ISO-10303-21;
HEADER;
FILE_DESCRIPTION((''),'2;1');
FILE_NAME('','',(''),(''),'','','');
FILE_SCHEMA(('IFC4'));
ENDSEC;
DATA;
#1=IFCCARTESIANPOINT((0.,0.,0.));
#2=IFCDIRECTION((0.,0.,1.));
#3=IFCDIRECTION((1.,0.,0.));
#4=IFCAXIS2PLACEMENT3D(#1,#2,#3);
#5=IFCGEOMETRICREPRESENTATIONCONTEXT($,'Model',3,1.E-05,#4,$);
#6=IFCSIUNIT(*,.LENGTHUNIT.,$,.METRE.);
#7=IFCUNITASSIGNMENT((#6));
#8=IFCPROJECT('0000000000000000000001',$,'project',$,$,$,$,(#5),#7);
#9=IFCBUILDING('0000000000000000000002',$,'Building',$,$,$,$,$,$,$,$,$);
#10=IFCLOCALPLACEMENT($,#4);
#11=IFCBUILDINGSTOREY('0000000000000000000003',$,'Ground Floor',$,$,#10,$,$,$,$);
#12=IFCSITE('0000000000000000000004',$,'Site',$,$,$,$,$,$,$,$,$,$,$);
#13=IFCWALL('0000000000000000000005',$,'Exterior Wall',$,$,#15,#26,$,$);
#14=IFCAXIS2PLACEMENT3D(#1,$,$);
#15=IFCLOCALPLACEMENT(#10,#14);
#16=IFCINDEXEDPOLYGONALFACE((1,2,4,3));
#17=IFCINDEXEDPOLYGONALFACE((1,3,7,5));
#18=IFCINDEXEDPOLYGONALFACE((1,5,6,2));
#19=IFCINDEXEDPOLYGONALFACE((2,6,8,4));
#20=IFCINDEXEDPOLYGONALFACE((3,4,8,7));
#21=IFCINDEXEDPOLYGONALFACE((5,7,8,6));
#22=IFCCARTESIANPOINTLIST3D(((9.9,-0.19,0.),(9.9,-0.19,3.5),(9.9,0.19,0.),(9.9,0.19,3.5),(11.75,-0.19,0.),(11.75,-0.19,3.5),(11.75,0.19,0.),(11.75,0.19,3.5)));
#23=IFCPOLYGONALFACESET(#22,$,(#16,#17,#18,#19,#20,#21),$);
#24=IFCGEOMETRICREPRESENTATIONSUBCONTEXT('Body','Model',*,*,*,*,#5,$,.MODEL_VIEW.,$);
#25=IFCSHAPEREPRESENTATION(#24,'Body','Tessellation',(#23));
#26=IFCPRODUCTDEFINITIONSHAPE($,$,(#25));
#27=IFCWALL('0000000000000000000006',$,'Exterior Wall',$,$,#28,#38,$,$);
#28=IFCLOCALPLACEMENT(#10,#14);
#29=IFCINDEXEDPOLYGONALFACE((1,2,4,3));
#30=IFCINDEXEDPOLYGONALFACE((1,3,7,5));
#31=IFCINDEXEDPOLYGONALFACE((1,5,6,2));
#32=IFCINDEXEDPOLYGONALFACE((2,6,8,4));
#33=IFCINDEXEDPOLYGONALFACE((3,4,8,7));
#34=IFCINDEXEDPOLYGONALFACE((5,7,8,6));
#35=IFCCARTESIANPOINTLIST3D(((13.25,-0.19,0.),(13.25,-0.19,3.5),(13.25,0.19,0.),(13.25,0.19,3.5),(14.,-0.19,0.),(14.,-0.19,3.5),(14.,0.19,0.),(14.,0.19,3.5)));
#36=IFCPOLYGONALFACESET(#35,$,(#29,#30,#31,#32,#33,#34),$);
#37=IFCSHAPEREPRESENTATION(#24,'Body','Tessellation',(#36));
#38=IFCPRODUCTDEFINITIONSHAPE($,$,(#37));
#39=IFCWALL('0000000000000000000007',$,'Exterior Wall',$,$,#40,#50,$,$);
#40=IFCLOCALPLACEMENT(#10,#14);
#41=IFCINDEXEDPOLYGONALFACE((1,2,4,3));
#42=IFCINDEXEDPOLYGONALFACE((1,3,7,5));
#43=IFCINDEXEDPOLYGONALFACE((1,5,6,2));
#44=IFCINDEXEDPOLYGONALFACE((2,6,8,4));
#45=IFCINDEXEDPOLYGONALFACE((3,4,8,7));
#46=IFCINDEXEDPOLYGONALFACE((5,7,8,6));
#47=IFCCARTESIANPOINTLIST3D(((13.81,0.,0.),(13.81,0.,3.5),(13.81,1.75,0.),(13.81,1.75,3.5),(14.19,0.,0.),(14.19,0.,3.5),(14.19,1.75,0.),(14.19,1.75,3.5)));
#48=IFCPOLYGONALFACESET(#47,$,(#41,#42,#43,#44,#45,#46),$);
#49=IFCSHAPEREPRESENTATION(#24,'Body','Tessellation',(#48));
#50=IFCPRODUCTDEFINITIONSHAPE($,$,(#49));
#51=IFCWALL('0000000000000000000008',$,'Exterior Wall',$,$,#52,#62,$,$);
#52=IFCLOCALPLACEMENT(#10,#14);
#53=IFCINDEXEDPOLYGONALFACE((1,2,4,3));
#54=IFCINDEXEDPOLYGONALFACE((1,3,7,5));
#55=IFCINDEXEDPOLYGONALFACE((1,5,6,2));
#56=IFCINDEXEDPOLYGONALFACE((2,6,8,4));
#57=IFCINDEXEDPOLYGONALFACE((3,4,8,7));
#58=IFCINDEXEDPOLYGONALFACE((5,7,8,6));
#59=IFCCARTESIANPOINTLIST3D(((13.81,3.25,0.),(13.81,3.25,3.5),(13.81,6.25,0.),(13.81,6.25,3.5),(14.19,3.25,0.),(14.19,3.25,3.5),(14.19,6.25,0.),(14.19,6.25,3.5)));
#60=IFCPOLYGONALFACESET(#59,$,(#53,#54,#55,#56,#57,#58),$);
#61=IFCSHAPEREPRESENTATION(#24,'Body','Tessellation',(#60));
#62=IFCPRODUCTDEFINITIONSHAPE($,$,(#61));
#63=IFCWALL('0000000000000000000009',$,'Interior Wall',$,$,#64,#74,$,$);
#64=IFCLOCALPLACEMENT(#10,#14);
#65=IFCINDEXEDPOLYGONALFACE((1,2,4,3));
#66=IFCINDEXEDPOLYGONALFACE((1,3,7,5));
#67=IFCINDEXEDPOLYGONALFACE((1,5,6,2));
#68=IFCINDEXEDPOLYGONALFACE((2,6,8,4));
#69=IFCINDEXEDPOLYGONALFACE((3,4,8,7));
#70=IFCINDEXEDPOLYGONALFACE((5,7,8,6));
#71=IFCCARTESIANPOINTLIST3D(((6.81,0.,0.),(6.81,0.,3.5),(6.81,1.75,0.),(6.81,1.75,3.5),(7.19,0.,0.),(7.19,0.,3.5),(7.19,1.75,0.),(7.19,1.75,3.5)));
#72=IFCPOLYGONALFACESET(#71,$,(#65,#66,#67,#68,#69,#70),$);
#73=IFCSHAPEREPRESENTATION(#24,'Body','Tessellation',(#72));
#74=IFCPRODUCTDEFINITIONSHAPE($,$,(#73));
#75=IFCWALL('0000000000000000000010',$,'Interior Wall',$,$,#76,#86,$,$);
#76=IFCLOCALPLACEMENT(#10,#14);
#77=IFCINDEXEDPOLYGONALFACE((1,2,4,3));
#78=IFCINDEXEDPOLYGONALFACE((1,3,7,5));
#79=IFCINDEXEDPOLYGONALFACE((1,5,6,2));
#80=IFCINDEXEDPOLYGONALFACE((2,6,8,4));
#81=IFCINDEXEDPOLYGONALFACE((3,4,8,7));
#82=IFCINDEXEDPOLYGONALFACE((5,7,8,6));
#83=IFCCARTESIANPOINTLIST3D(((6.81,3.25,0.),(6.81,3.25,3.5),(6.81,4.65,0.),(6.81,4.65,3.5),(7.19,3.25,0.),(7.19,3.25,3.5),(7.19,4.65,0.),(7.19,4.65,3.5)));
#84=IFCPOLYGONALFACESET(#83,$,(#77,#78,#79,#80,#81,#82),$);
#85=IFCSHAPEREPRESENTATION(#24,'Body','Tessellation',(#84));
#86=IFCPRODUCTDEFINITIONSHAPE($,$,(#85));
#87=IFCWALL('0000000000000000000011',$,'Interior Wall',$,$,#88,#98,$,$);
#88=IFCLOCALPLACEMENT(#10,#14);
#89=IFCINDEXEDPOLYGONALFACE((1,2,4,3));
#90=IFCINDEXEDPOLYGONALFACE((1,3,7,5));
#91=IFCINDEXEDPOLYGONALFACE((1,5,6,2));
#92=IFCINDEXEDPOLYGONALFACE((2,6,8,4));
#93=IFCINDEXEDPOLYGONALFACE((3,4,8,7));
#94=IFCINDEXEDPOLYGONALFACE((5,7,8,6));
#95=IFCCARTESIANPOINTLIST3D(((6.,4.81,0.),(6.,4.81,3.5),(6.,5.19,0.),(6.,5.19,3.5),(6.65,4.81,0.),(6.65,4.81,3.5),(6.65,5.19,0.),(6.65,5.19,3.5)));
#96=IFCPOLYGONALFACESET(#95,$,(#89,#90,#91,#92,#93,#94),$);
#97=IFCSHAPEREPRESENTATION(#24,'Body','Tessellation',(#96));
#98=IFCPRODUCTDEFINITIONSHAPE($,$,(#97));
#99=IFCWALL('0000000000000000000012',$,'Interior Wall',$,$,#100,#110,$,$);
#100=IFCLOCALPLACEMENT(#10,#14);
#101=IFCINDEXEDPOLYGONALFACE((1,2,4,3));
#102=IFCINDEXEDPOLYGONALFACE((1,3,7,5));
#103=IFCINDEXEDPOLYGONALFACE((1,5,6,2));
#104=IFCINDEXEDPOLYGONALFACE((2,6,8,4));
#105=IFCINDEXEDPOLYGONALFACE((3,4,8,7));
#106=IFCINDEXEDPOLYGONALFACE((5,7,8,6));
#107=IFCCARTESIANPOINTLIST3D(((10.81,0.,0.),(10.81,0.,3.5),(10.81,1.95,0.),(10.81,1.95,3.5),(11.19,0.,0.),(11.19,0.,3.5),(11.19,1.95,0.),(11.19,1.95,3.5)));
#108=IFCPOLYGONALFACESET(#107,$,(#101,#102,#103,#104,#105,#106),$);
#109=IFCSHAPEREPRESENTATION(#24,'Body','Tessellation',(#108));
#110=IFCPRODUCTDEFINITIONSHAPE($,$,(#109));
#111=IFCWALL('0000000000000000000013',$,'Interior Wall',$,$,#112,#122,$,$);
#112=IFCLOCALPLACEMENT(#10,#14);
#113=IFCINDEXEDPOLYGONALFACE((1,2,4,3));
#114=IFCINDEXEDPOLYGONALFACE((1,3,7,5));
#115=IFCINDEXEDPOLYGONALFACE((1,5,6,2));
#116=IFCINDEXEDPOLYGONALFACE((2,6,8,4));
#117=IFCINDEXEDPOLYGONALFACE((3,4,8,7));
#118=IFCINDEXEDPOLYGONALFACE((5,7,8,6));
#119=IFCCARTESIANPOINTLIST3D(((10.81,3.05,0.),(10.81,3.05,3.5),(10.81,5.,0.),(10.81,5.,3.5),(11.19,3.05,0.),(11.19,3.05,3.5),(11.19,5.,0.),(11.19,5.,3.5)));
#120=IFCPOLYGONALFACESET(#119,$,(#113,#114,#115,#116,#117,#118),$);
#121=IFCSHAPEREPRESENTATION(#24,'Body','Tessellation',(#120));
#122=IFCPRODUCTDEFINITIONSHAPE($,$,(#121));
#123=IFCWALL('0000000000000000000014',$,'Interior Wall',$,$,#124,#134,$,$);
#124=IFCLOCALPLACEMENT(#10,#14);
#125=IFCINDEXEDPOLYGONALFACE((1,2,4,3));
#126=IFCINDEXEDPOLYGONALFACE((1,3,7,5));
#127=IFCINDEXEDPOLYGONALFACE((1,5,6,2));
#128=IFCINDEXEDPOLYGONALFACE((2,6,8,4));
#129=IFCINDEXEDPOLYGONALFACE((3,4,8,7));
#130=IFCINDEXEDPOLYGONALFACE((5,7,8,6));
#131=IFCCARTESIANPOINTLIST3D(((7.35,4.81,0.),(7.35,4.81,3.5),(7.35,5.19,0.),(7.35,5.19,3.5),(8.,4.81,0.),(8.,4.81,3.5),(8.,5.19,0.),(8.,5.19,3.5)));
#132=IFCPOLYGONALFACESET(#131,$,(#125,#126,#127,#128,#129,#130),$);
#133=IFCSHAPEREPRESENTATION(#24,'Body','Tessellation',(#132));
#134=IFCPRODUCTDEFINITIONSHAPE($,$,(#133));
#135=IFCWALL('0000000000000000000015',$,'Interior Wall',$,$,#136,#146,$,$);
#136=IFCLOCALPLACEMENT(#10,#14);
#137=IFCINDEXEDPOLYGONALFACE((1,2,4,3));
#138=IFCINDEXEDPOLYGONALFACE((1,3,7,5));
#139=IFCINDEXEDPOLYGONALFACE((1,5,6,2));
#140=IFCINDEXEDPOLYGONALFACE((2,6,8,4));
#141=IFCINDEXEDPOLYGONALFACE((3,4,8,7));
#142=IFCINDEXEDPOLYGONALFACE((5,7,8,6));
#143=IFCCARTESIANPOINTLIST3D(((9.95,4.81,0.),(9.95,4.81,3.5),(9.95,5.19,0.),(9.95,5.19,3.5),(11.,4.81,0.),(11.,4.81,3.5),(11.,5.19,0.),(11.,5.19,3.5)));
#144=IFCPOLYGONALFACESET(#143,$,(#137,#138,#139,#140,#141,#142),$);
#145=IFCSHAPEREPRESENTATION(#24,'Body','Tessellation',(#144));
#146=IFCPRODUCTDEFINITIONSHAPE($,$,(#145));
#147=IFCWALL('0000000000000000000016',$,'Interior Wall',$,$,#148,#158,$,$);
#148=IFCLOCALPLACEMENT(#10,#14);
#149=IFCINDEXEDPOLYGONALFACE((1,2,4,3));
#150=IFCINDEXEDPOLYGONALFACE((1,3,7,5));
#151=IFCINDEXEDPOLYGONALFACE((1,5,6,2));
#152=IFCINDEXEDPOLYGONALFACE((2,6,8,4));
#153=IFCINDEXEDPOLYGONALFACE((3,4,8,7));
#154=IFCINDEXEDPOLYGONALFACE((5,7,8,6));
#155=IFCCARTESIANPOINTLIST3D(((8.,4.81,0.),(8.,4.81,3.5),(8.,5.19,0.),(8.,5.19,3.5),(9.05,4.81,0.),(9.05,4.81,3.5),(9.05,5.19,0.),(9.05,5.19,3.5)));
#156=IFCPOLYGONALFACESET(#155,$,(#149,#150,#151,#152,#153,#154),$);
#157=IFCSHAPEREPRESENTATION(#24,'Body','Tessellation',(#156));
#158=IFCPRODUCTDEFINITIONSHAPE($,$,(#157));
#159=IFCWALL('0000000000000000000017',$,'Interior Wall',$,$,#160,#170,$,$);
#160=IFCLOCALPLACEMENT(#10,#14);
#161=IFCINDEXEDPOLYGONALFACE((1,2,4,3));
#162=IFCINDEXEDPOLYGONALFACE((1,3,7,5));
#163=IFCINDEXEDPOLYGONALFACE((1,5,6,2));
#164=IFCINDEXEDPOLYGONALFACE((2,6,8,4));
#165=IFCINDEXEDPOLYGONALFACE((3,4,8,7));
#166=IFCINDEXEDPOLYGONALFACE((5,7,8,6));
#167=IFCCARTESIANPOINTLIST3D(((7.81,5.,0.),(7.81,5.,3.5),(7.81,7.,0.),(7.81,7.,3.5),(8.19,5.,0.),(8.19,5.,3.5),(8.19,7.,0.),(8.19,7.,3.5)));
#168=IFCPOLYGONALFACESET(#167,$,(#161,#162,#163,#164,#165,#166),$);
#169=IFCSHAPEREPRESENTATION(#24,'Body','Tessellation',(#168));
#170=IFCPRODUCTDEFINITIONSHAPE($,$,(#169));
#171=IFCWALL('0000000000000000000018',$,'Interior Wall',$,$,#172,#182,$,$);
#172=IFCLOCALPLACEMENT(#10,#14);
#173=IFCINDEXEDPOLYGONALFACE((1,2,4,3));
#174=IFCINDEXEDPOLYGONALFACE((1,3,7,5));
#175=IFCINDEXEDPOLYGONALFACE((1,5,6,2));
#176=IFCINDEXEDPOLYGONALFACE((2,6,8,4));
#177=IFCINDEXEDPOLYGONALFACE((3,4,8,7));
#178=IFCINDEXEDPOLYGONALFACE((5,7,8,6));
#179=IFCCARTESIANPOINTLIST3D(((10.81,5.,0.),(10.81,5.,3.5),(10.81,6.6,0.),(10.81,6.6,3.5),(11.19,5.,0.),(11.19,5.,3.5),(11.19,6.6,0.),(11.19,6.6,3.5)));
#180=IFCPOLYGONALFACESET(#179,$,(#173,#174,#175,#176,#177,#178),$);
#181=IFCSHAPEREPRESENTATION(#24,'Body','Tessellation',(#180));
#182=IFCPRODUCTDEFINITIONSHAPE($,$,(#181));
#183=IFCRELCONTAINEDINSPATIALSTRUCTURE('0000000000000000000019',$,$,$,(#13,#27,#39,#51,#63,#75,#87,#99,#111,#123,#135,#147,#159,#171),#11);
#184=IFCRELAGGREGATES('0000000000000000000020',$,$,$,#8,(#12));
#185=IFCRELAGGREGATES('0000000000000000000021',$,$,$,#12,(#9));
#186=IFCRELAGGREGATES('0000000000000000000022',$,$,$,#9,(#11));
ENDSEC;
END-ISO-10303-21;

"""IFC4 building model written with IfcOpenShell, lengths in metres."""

from ifc_helpers import new_model, si_unit, frame, origin_with_axes, place, context, subcontext, project, spatial, indexed_curve, outline, extrude, element, save


model = new_model("IFC4")

# Units and contexts
model_context = context("Model", 3, precision=1e-05, world=origin_with_axes())
body_context = subcontext(model_context, "Body", "Model", "MODEL_VIEW")
ifc_project = project(units=[si_unit("LENGTHUNIT", "METRE")], contexts=[model_context])

# Site, building, storey
site = spatial("IfcSite", under=ifc_project, Name="Site")
building = spatial("IfcBuilding", under=site, Name="Building")
storey_placement = place(None, origin_with_axes())
storey = spatial("IfcBuildingStorey", under=building, at=storey_placement, Name="Ground Floor")

# Walls
wall_1_placement = place(storey_placement, frame((9.9, 0.0, 0.0), z_axis=(0.0, 0.0, 1.0), x_axis=(1.0, 0.0, 0.0)))
element("IfcWall", 1, at=wall_1_placement, inside=storey, Name="Exterior Wall", context=body_context, shape_type="SweptSolid", body=[
    extrude(outline(indexed_curve([(0.0, 0.0), (0.0, 0.38), (1.85, 0.38), (1.85, 0.0), (0.0, 0.0)], self_intersect=False)), frame((0.0, -0.19, 0.0), z_axis=(0.0, 0.0, 1.0), x_axis=(1.0, 0.0, 0.0)), (0.0, 0.0, 1.0), 3.5),
])
wall_2_placement = place(storey_placement, frame((13.25, 0.0, 0.0), z_axis=(0.0, 0.0, 1.0), x_axis=(1.0, 0.0, 0.0)))
element("IfcWall", 2, at=wall_2_placement, inside=storey, Name="Exterior Wall", context=body_context, shape_type="SweptSolid", body=[
    extrude(outline(indexed_curve([(0.0, 0.0), (0.0, 0.38), (0.75, 0.38), (0.75, 0.0), (0.0, 0.0)], self_intersect=False)), frame((0.0, -0.19, 0.0), z_axis=(0.0, 0.0, 1.0), x_axis=(1.0, 0.0, 0.0)), (0.0, 0.0, 1.0), 3.5),
])
wall_3_placement = place(storey_placement, frame((14.0, 0.0, 0.0), z_axis=(0.0, 0.0, 1.0), x_axis=(0.0, 1.0, 0.0)))
element("IfcWall", 3, at=wall_3_placement, inside=storey, Name="Exterior Wall", context=body_context, shape_type="SweptSolid", body=[
    extrude(outline(indexed_curve([(0.0, 0.0), (0.0, 0.38), (1.75, 0.38), (1.75, 0.0), (0.0, 0.0)], self_intersect=False)), frame((0.0, -0.19, 0.0), z_axis=(0.0, 0.0, 1.0), x_axis=(1.0, 0.0, 0.0)), (0.0, 0.0, 1.0), 3.5),
])
wall_4_placement = place(storey_placement, frame((14.0, 3.25, 0.0), z_axis=(0.0, 0.0, 1.0), x_axis=(0.0, 1.0, 0.0)))
element("IfcWall", 4, at=wall_4_placement, inside=storey, Name="Exterior Wall", context=body_context, shape_type="SweptSolid", body=[
    extrude(outline(indexed_curve([(0.0, 0.0), (0.0, 0.38), (3.0, 0.38), (3.0, 0.0), (0.0, 0.0)], self_intersect=False)), frame((0.0, -0.19, 0.0), z_axis=(0.0, 0.0, 1.0), x_axis=(1.0, 0.0, 0.0)), (0.0, 0.0, 1.0), 3.5),
])
wall_5_placement = place(storey_placement, frame((7.0, 0.0, 0.0), z_axis=(0.0, 0.0, 1.0), x_axis=(0.0, 1.0, 0.0)))
element("IfcWall", 5, at=wall_5_placement, inside=storey, Name="Interior Wall", context=body_context, shape_type="SweptSolid", body=[
    extrude(outline(indexed_curve([(0.0, 0.0), (0.0, 0.38), (1.75, 0.38), (1.75, 0.0), (0.0, 0.0)], self_intersect=False)), frame((0.0, -0.19, 0.0), z_axis=(0.0, 0.0, 1.0), x_axis=(1.0, 0.0, 0.0)), (0.0, 0.0, 1.0), 3.5),
])
wall_6_placement = place(storey_placement, frame((7.0, 3.25, 0.0), z_axis=(0.0, 0.0, 1.0), x_axis=(0.0, 1.0, 0.0)))
element("IfcWall", 6, at=wall_6_placement, inside=storey, Name="Interior Wall", context=body_context, shape_type="SweptSolid", body=[
    extrude(outline(indexed_curve([(0.0, 0.0), (0.0, 0.38), (1.4, 0.38), (1.4, 0.0), (0.0, 0.0)], self_intersect=False)), frame((0.0, -0.19, 0.0), z_axis=(0.0, 0.0, 1.0), x_axis=(1.0, 0.0, 0.0)), (0.0, 0.0, 1.0), 3.5),
])
wall_7_placement = place(storey_placement, frame((6.65, 5.0, 0.0), z_axis=(0.0, 0.0, 1.0), x_axis=(-1.0, 0.0, 0.0)))
element("IfcWall", 7, at=wall_7_placement, inside=storey, Name="Interior Wall", context=body_context, shape_type="SweptSolid", body=[
    extrude(outline(indexed_curve([(0.0, 0.0), (0.0, 0.38), (0.65, 0.38), (0.65, 0.0), (0.0, 0.0)], self_intersect=False)), frame((0.0, -0.19, 0.0), z_axis=(0.0, 0.0, 1.0), x_axis=(1.0, 0.0, 0.0)), (0.0, 0.0, 1.0), 3.5),
])
wall_8_placement = place(storey_placement, frame((11.0, 0.0, 0.0), z_axis=(0.0, 0.0, 1.0), x_axis=(0.0, 1.0, 0.0)))
element("IfcWall", 8, at=wall_8_placement, inside=storey, Name="Interior Wall", context=body_context, shape_type="SweptSolid", body=[
    extrude(outline(indexed_curve([(0.0, 0.0), (0.0, 0.38), (1.95, 0.38), (1.95, 0.0), (0.0, 0.0)], self_intersect=False)), frame((0.0, -0.19, 0.0), z_axis=(0.0, 0.0, 1.0), x_axis=(1.0, 0.0, 0.0)), (0.0, 0.0, 1.0), 3.5),
])
wall_9_placement = place(storey_placement, frame((11.0, 3.05, 0.0), z_axis=(0.0, 0.0, 1.0), x_axis=(0.0, 1.0, 0.0)))
element("IfcWall", 9, at=wall_9_placement, inside=storey, Name="Interior Wall", context=body_context, shape_type="SweptSolid", body=[
    extrude(outline(indexed_curve([(0.0, 0.0), (0.0, 0.38), (1.95, 0.38), (1.95, 0.0), (0.0, 0.0)], self_intersect=False)), frame((0.0, -0.19, 0.0), z_axis=(0.0, 0.0, 1.0), x_axis=(1.0, 0.0, 0.0)), (0.0, 0.0, 1.0), 3.5),
])
wall_10_placement = place(storey_placement, frame((8.0, 5.0, 0.0), z_axis=(0.0, 0.0, 1.0), x_axis=(-1.0, 0.0, 0.0)))
element("IfcWall", 10, at=wall_10_placement, inside=storey, Name="Interior Wall", context=body_context, shape_type="SweptSolid", body=[
    extrude(outline(indexed_curve([(0.0, 0.0), (0.0, 0.38), (0.65, 0.38), (0.65, 0.0), (0.0, 0.0)], self_intersect=False)), frame((0.0, -0.19, 0.0), z_axis=(0.0, 0.0, 1.0), x_axis=(1.0, 0.0, 0.0)), (0.0, 0.0, 1.0), 3.5),
])
for number, where, z_axis, x_axis, name in (
    (11, (11.0, 5.0, 0.0), (0.0, 0.0, 1.0), (-1.0, 0.0, 0.0), "Interior Wall"),
    (12, (9.05, 5.0, 0.0), (0.0, 0.0, 1.0), (-1.0, 0.0, 0.0), "Interior Wall"),
):
    element("IfcWall", number, at=place(storey_placement, frame(where, z_axis=z_axis, x_axis=x_axis)), inside=storey, Name=name, context=body_context, shape_type="SweptSolid", body=[
        extrude(outline(indexed_curve([(0.0, 0.0), (0.0, 0.38), (1.05, 0.38), (1.05, 0.0), (0.0, 0.0)], self_intersect=False)), frame((0.0, -0.19, 0.0), z_axis=(0.0, 0.0, 1.0), x_axis=(1.0, 0.0, 0.0)), (0.0, 0.0, 1.0), 3.5),
    ])
wall_11_placement = place(storey_placement, frame((8.0, 5.0, 0.0), z_axis=(0.0, 0.0, 1.0), x_axis=(0.0, 1.0, 0.0)))
element("IfcWall", 13, at=wall_11_placement, inside=storey, Name="Interior Wall", context=body_context, shape_type="SweptSolid", body=[
    extrude(outline(indexed_curve([(0.0, 0.0), (0.0, 0.38), (2.0, 0.38), (2.0, 0.0), (0.0, 0.0)], self_intersect=False)), frame((0.0, -0.19, 0.0), z_axis=(0.0, 0.0, 1.0), x_axis=(1.0, 0.0, 0.0)), (0.0, 0.0, 1.0), 3.5),
])
wall_12_placement = place(storey_placement, frame((11.0, 5.0, 0.0), z_axis=(0.0, 0.0, 1.0), x_axis=(0.0, 1.0, 0.0)))
element("IfcWall", 14, at=wall_12_placement, inside=storey, Name="Interior Wall", context=body_context, shape_type="SweptSolid", body=[
    extrude(outline(indexed_curve([(0.0, 0.0), (0.0, 0.38), (1.6, 0.38), (1.6, 0.0), (0.0, 0.0)], self_intersect=False)), frame((0.0, -0.19, 0.0), z_axis=(0.0, 0.0, 1.0), x_axis=(1.0, 0.0, 0.0)), (0.0, 0.0, 1.0), 3.5),
])

save(model, "model.ifc")
